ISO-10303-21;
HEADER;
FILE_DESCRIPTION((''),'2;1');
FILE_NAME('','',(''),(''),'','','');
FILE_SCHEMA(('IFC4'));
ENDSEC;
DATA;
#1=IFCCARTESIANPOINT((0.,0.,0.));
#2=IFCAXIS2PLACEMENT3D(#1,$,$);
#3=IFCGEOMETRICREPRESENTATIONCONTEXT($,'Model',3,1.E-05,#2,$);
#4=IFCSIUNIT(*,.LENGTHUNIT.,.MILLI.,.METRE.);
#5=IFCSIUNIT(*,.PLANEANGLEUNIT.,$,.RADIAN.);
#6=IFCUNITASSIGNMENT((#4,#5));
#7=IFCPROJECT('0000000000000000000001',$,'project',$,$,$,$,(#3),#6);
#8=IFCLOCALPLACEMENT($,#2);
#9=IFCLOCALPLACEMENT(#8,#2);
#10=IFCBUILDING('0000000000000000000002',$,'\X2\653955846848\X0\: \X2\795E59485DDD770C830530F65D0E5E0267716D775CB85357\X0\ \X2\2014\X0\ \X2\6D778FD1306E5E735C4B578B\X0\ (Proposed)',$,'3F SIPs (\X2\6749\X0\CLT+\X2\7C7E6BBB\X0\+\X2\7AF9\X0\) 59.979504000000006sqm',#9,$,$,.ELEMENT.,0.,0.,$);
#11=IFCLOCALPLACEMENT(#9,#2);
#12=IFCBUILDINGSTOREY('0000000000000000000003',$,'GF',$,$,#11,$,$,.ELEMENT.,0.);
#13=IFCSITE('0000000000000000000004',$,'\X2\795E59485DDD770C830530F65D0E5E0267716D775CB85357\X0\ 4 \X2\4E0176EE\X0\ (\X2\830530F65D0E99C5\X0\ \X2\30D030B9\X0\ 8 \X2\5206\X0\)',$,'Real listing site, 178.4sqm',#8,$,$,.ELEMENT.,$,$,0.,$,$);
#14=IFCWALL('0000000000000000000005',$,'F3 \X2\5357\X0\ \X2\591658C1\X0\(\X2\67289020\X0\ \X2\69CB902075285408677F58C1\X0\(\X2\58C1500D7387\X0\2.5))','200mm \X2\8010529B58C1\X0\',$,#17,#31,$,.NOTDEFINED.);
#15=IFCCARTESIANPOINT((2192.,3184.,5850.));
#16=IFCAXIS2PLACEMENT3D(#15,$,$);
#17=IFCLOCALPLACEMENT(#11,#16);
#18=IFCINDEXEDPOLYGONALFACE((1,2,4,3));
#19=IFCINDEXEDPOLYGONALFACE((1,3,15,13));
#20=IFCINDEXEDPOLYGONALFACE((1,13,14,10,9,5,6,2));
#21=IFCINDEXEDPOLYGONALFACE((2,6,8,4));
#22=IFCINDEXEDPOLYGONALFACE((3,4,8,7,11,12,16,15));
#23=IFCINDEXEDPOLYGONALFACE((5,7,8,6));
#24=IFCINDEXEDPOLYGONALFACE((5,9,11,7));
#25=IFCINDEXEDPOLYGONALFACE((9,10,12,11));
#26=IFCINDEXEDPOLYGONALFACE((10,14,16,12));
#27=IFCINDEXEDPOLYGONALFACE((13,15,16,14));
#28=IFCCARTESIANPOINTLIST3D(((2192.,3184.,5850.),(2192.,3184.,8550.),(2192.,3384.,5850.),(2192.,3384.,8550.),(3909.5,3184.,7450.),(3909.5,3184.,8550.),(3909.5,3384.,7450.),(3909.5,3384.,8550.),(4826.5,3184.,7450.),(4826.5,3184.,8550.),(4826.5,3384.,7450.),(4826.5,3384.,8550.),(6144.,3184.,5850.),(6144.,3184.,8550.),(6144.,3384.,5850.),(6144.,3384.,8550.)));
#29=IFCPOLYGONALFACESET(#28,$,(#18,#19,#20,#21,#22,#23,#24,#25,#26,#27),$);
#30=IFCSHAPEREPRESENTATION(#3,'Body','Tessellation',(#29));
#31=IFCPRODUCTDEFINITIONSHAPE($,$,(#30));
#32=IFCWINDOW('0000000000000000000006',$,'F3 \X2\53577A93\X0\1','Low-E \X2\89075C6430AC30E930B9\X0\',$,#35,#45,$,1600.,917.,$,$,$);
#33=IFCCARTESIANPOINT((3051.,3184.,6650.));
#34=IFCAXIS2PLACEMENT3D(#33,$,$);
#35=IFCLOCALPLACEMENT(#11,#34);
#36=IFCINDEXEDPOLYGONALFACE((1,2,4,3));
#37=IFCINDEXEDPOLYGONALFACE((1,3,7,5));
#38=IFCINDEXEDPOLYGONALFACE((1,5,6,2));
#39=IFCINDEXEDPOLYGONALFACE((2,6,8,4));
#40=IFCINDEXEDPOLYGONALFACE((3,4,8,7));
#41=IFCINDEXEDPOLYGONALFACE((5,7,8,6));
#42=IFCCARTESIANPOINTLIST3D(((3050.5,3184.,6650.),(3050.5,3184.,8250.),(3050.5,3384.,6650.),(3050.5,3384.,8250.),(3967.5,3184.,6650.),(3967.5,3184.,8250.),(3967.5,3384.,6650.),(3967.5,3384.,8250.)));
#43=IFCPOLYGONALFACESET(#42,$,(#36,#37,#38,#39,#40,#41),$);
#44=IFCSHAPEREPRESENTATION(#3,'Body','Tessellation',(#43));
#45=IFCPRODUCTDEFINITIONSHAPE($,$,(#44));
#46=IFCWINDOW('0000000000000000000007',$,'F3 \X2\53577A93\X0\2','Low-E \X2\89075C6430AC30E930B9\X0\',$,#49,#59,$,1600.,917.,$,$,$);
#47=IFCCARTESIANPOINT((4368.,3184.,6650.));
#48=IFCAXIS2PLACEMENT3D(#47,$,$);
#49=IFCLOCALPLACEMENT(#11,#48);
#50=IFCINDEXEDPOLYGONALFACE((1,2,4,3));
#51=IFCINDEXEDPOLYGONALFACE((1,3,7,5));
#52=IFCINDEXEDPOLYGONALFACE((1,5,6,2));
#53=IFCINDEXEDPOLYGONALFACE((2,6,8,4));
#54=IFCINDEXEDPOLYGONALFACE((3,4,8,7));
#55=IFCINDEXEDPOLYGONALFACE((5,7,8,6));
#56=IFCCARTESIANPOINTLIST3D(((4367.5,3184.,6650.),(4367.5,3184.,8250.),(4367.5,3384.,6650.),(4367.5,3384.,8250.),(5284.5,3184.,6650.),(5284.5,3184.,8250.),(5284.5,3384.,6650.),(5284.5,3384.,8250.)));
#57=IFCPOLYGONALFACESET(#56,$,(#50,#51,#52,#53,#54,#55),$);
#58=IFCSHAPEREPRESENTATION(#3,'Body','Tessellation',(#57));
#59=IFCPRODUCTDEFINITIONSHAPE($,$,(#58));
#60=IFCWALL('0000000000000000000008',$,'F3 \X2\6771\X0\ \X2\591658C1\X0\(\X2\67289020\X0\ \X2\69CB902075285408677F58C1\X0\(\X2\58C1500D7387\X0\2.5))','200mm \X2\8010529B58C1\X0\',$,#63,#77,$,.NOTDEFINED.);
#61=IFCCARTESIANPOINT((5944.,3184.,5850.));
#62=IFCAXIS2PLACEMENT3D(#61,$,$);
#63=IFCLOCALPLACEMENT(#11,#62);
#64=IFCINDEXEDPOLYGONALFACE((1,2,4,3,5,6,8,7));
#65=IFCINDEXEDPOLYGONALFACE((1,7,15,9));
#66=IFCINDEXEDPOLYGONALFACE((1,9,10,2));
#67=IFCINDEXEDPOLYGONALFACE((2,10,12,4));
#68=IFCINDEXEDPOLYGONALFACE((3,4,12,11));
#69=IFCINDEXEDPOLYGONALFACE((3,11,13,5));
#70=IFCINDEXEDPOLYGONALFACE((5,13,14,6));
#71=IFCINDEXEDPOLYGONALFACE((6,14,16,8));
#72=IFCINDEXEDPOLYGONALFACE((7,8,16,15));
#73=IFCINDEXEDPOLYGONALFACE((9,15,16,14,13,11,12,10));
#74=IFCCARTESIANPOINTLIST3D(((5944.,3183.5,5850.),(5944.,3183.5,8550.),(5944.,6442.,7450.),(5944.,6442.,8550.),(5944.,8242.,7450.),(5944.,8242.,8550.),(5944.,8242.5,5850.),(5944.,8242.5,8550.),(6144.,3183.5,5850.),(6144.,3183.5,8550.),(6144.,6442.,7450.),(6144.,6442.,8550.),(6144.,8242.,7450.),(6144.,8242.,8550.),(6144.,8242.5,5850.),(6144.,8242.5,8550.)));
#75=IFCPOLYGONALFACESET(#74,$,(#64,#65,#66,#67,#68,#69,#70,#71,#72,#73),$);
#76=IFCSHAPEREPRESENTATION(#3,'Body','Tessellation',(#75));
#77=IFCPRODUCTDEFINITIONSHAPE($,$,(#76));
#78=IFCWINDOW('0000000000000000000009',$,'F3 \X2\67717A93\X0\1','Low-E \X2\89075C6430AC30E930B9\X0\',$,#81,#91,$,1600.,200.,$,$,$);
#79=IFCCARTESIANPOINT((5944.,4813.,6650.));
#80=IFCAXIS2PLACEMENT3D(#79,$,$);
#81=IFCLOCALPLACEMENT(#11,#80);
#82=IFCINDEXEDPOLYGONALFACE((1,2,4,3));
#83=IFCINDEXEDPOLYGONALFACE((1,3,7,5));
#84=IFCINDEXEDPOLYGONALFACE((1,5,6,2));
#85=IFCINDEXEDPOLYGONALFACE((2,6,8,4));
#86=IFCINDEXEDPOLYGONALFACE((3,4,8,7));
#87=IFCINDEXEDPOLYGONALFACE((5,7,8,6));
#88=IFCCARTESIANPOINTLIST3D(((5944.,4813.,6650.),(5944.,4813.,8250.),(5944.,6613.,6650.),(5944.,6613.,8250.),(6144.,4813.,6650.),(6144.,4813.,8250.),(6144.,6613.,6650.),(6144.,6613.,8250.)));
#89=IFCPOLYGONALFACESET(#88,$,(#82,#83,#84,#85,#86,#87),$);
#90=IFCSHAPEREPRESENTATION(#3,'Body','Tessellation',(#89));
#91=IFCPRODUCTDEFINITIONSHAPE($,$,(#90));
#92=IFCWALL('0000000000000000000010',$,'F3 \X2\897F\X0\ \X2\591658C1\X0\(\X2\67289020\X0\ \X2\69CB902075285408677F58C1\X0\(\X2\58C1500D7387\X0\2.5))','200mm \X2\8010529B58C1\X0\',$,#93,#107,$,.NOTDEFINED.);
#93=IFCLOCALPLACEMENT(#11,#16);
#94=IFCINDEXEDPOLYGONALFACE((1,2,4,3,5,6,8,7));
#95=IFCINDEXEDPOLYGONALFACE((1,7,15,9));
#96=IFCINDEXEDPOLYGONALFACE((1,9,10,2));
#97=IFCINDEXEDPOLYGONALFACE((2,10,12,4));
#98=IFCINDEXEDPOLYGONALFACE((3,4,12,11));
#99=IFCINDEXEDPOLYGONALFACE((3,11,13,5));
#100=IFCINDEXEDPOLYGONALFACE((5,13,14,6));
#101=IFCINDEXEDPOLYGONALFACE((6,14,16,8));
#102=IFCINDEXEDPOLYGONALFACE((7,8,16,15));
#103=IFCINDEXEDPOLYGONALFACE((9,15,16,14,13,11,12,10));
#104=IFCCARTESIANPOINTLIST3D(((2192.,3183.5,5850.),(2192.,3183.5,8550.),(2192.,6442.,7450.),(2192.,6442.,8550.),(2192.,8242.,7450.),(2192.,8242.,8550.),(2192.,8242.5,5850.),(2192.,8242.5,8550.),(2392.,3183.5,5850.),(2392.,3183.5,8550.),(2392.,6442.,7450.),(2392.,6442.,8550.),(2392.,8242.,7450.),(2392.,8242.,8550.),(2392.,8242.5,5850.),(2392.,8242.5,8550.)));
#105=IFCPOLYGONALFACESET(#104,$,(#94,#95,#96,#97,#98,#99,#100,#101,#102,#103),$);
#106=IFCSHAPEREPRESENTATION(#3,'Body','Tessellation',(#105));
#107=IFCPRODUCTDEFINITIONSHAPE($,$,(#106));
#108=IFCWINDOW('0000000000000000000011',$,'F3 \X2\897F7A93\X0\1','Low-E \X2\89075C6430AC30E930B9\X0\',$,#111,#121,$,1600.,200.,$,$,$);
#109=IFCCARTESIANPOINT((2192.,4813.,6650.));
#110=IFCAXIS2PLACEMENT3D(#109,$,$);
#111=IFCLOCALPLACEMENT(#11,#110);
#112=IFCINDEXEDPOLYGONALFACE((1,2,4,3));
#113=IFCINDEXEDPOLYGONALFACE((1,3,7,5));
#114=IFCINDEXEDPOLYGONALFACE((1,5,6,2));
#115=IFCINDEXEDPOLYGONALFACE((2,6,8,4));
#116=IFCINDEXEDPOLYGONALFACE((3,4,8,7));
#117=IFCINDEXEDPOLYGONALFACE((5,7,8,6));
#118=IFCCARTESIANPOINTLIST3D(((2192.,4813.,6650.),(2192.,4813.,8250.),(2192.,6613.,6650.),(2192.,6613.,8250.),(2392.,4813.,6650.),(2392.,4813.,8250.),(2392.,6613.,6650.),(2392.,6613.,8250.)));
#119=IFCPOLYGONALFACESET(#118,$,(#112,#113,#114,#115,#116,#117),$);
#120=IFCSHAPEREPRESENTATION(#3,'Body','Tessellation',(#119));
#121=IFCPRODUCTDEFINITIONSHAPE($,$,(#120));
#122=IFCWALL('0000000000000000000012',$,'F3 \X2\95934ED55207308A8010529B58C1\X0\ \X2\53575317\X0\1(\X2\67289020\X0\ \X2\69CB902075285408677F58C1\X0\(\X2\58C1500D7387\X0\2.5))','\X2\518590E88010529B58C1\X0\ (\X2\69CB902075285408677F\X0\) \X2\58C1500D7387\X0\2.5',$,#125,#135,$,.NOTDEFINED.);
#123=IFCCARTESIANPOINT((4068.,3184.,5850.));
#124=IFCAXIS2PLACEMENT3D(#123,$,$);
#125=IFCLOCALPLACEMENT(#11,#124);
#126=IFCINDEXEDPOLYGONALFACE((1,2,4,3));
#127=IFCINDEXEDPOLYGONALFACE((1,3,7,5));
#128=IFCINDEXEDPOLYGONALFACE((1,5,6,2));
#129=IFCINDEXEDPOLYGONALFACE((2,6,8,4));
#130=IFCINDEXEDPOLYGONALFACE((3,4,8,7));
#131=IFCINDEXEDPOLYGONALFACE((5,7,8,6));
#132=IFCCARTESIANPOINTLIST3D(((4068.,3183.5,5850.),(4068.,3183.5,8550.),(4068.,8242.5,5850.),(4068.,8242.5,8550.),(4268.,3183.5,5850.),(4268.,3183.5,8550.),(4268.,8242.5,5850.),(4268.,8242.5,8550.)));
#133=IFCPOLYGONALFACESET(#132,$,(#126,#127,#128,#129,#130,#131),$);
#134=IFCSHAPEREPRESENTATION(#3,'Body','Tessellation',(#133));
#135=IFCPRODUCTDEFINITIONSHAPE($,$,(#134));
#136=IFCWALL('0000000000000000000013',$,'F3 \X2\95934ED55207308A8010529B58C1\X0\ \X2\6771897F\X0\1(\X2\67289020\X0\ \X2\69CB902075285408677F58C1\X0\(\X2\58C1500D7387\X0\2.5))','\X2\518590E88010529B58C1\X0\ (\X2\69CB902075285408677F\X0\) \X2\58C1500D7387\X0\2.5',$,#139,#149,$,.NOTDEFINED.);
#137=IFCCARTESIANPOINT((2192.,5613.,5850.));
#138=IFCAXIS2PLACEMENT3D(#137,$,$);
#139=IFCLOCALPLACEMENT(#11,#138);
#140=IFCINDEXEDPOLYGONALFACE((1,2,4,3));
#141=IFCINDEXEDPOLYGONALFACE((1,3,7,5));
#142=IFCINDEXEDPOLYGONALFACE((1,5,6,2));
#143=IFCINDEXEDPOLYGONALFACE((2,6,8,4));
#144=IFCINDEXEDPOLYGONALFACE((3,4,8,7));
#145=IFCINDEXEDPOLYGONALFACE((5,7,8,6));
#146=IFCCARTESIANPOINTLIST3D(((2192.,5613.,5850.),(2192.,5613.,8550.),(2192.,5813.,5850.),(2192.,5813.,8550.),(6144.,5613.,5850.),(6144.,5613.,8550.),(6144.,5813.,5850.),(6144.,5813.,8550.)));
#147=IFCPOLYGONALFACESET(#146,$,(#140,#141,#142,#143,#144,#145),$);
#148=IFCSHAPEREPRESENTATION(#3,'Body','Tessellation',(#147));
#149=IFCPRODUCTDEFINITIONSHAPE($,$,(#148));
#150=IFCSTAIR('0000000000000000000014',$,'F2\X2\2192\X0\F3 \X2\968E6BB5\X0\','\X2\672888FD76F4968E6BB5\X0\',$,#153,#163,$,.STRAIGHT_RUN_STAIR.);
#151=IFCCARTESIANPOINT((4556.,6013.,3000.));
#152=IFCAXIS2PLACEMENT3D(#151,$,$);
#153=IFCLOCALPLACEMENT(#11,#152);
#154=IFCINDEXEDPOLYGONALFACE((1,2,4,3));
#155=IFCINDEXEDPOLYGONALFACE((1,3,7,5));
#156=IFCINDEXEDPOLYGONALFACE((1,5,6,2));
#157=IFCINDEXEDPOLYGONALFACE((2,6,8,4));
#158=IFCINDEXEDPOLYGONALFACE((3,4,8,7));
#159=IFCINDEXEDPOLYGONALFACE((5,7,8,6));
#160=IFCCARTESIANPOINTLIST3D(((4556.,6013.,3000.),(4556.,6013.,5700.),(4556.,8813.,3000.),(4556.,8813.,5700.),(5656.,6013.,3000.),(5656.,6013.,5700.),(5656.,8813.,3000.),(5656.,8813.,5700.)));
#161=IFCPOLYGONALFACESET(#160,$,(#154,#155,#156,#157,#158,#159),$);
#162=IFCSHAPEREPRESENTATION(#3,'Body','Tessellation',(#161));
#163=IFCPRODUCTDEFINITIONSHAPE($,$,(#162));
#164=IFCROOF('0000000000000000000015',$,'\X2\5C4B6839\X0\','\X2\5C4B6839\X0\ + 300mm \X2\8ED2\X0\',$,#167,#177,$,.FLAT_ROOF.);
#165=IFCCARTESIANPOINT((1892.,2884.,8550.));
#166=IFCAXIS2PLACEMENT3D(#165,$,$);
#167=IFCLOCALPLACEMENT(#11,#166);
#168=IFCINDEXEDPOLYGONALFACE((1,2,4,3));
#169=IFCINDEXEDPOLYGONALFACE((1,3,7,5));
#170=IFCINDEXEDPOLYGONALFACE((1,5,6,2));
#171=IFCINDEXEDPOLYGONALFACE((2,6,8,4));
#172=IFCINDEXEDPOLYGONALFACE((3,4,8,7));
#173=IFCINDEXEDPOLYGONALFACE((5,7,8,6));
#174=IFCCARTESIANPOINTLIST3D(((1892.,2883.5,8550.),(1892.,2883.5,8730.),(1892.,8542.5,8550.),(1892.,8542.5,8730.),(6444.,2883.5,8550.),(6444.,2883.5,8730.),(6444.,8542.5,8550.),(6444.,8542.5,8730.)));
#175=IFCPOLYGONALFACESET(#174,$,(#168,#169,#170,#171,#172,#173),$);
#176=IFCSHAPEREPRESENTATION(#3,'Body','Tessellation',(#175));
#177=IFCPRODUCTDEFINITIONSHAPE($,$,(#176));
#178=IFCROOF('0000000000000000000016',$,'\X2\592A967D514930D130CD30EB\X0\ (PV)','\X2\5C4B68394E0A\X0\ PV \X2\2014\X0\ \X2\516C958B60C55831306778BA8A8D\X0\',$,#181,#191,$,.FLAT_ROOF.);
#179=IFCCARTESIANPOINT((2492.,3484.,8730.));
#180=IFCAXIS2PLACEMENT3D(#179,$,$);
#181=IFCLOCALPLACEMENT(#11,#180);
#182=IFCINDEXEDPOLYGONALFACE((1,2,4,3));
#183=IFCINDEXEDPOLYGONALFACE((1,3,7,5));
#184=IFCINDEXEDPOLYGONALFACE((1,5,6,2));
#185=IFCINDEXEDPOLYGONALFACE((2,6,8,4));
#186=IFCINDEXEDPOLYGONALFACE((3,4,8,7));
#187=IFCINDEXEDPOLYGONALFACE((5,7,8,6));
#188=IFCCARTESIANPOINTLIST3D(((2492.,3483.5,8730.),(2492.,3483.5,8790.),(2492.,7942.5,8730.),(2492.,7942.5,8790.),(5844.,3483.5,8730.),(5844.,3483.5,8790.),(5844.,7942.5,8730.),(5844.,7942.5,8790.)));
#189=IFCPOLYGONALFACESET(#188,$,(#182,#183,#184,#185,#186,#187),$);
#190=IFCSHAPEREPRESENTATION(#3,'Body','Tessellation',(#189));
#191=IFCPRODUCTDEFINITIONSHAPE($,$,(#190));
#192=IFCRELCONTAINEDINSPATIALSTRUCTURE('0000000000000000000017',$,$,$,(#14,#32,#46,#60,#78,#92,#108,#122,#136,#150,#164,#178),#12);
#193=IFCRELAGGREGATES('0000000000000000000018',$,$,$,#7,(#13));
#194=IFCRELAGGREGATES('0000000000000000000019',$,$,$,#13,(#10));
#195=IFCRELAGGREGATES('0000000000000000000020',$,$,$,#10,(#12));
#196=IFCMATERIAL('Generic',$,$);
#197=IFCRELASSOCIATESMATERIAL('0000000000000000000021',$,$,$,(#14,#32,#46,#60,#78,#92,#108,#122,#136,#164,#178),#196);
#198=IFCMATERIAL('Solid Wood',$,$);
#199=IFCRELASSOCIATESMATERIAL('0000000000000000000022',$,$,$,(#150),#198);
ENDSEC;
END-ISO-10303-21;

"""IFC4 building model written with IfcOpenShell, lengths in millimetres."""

from ifc_helpers import new_model, si_unit, frame, frame_2d, origin, place, context, project, spatial, rectangle, extrude, material, element, fill, save


model = new_model("IFC4")

# Units and contexts
model_context = context("Model", 3, precision=1e-05, world=origin())
ifc_project = project(units=[si_unit("LENGTHUNIT", "METRE", prefix="MILLI"), si_unit("PLANEANGLEUNIT", "RADIAN")], contexts=[model_context])

# Site, building, storey
site_placement = place(None, origin())
site = spatial("IfcSite", under=ifc_project, at=site_placement, Name="神奈川県茅ヶ崎市東海岸南 4 丁目 (茅ヶ崎駅 バス 8 分)", ObjectType="Real listing site, 178.4sqm", CompositionType="ELEMENT", RefElevation=0.0)
building_placement = place(site_placement, origin())
building = spatial("IfcBuilding", under=site, at=building_placement, Name="改善案: 神奈川県茅ヶ崎市東海岸南 — 海近の平屋型 (Proposed)", ObjectType="3F SIPs (杉CLT+籾殻+竹) 59.979504000000006sqm", CompositionType="ELEMENT", ElevationOfRefHeight=0.0, ElevationOfTerrain=0.0)
storey_placement = place(building_placement, origin())
storey = spatial("IfcBuildingStorey", under=building, at=storey_placement, Name="GF", CompositionType="ELEMENT", Elevation=0.0)

# Shared definitions
ifc_material_1 = material(Name="Generic")

# Wall, openings, windows
wall_1_placement = place(storey_placement, frame((2192.0, 3184.0, 5850.0)))
wall_1 = element("IfcWall", 1, at=wall_1_placement, inside=storey, material=ifc_material_1, Name="F3 南 外壁(木造 構造用合板壁(壁倍率2.5))", Description="200mm 耐力壁", PredefinedType="NOTDEFINED", context=model_context, shape_type="SweptSolid", body=[
    extrude(rectangle(XDim=3952.0, YDim=200.0, at=frame_2d((1976.0, 100.0))), frame((2192.0, 3184.0, 5850.0)), (0.0, 0.0, 1.0), 2700.0),
])
opening_1_placement = place(storey_placement, frame((3051.0, 3184.0, 6650.0)))
opening_1 = element("IfcOpeningElement", 2, at=opening_1_placement, cuts=wall_1, PredefinedType="NOTDEFINED", context=model_context, shape_type="SweptSolid", body=[
    extrude(rectangle(XDim=917.0, YDim=200.0, at=frame_2d((458.0, 100.0))), frame((3051.0, 3184.0, 6650.0)), (0.0, 0.0, 1.0), 1600.0),
])
opening_2_placement = place(storey_placement, frame((4368.0, 3184.0, 6650.0)))
opening_2 = element("IfcOpeningElement", 3, at=opening_2_placement, cuts=wall_1, PredefinedType="NOTDEFINED", context=model_context, shape_type="SweptSolid", body=[
    extrude(rectangle(XDim=917.0, YDim=200.0, at=frame_2d((458.0, 100.0))), frame((4368.0, 3184.0, 6650.0)), (0.0, 0.0, 1.0), 1600.0),
])
window_1_placement = place(storey_placement, frame((3051.0, 3184.0, 6650.0)))
window_1 = element("IfcWindow", 4, at=window_1_placement, inside=storey, material=ifc_material_1, Name="F3 南窓1", Description="Low-E 複層ガラス", OverallHeight=1600.0, OverallWidth=917.0, context=model_context, shape_type="SweptSolid", body=[
    extrude(rectangle(XDim=917.0, YDim=200.0, at=frame_2d((458.0, 100.0))), frame((3051.0, 3184.0, 6650.0)), (0.0, 0.0, 1.0), 1600.0),
])
fill(opening_1, window_1)
window_2_placement = place(storey_placement, frame((4368.0, 3184.0, 6650.0)))
window_2 = element("IfcWindow", 5, at=window_2_placement, inside=storey, material=ifc_material_1, Name="F3 南窓2", Description="Low-E 複層ガラス", OverallHeight=1600.0, OverallWidth=917.0, context=model_context, shape_type="SweptSolid", body=[
    extrude(rectangle(XDim=917.0, YDim=200.0, at=frame_2d((458.0, 100.0))), frame((4368.0, 3184.0, 6650.0)), (0.0, 0.0, 1.0), 1600.0),
])
fill(opening_2, window_2)

# Walls, openings, windows
wall_2_placement = place(storey_placement, frame((5944.0, 3184.0, 5850.0)))
wall_2 = element("IfcWall", 6, at=wall_2_placement, inside=storey, material=ifc_material_1, Name="F3 東 外壁(木造 構造用合板壁(壁倍率2.5))", Description="200mm 耐力壁", PredefinedType="NOTDEFINED", context=model_context, shape_type="SweptSolid", body=[
    extrude(rectangle(XDim=200.0, YDim=5059.0, at=frame_2d((100.0, 2529.0))), frame((5944.0, 3184.0, 5850.0)), (0.0, 0.0, 1.0), 2700.0),
])
opening_3_placement = place(storey_placement, frame((5944.0, 4813.0, 6650.0)))
opening_3 = element("IfcOpeningElement", 7, at=opening_3_placement, cuts=wall_2, PredefinedType="NOTDEFINED", context=model_context, shape_type="SweptSolid", body=[
    extrude(rectangle(XDim=200.0, YDim=1800.0, at=frame_2d((100.0, 900.0))), frame((5944.0, 4813.0, 6650.0)), (0.0, 0.0, 1.0), 1600.0),
])
window_3_placement = place(storey_placement, frame((5944.0, 4813.0, 6650.0)))
window_3 = element("IfcWindow", 8, at=window_3_placement, inside=storey, material=ifc_material_1, Name="F3 東窓1", Description="Low-E 複層ガラス", OverallHeight=1600.0, OverallWidth=200.0, context=model_context, shape_type="SweptSolid", body=[
    extrude(rectangle(XDim=200.0, YDim=1800.0, at=frame_2d((100.0, 900.0))), frame((5944.0, 4813.0, 6650.0)), (0.0, 0.0, 1.0), 1600.0),
])
fill(opening_3, window_3)
wall_3_placement = place(storey_placement, frame((2192.0, 3184.0, 5850.0)))
wall_3 = element("IfcWall", 9, at=wall_3_placement, inside=storey, material=ifc_material_1, Name="F3 西 外壁(木造 構造用合板壁(壁倍率2.5))", Description="200mm 耐力壁", PredefinedType="NOTDEFINED", context=model_context, shape_type="SweptSolid", body=[
    extrude(rectangle(XDim=200.0, YDim=5059.0, at=frame_2d((100.0, 2529.0))), frame((2192.0, 3184.0, 5850.0)), (0.0, 0.0, 1.0), 2700.0),
])
opening_4_placement = place(storey_placement, frame((2192.0, 4813.0, 6650.0)))
opening_4 = element("IfcOpeningElement", 10, at=opening_4_placement, cuts=wall_3, PredefinedType="NOTDEFINED", context=model_context, shape_type="SweptSolid", body=[
    extrude(rectangle(XDim=200.0, YDim=1800.0, at=frame_2d((100.0, 900.0))), frame((2192.0, 4813.0, 6650.0)), (0.0, 0.0, 1.0), 1600.0),
])
window_4_placement = place(storey_placement, frame((2192.0, 4813.0, 6650.0)))
window_4 = element("IfcWindow", 11, at=window_4_placement, inside=storey, material=ifc_material_1, Name="F3 西窓1", Description="Low-E 複層ガラス", OverallHeight=1600.0, OverallWidth=200.0, context=model_context, shape_type="SweptSolid", body=[
    extrude(rectangle(XDim=200.0, YDim=1800.0, at=frame_2d((100.0, 900.0))), frame((2192.0, 4813.0, 6650.0)), (0.0, 0.0, 1.0), 1600.0),
])
fill(opening_4, window_4)

# Walls
wall_4_placement = place(storey_placement, frame((4068.0, 3184.0, 5850.0)))
element("IfcWall", 12, at=wall_4_placement, inside=storey, material=ifc_material_1, Name="F3 間仕切り耐力壁 南北1(木造 構造用合板壁(壁倍率2.5))", Description="内部耐力壁 (構造用合板) 壁倍率2.5", PredefinedType="NOTDEFINED", context=model_context, shape_type="SweptSolid", body=[
    extrude(rectangle(XDim=200.0, YDim=5059.0, at=frame_2d((100.0, 2529.0))), frame((4068.0, 3184.0, 5850.0)), (0.0, 0.0, 1.0), 2700.0),
])
wall_5_placement = place(storey_placement, frame((2192.0, 5613.0, 5850.0)))
element("IfcWall", 13, at=wall_5_placement, inside=storey, material=ifc_material_1, Name="F3 間仕切り耐力壁 東西1(木造 構造用合板壁(壁倍率2.5))", Description="内部耐力壁 (構造用合板) 壁倍率2.5", PredefinedType="NOTDEFINED", context=model_context, shape_type="SweptSolid", body=[
    extrude(rectangle(XDim=3952.0, YDim=200.0, at=frame_2d((1976.0, 100.0))), frame((2192.0, 5613.0, 5850.0)), (0.0, 0.0, 1.0), 2700.0),
])

# Stair
ifc_material_2 = material(Name="Solid Wood")
stair_placement = place(storey_placement, frame((4556.0, 6013.0, 3000.0)))
element("IfcStair", 14, at=stair_placement, inside=storey, material=ifc_material_2, Name="F2→F3 階段", Description="木製直階段", PredefinedType="STRAIGHT_RUN_STAIR", context=model_context, shape_type="SweptSolid", body=[
    extrude(rectangle(XDim=1100.0, YDim=2800.0, at=frame_2d((550.0, 1400.0))), frame((4556.0, 6013.0, 3000.0)), (0.0, 0.0, 1.0), 2700.0),
])

# Roofs
roof_1_placement = place(storey_placement, frame((1892.0, 2884.0, 8550.0)))
element("IfcRoof", 15, at=roof_1_placement, inside=storey, material=ifc_material_1, Name="屋根", Description="屋根 + 300mm 軒", PredefinedType="FLAT_ROOF", context=model_context, shape_type="SweptSolid", body=[
    extrude(rectangle(XDim=4552.0, YDim=5659.0, at=frame_2d((2276.0, 2829.0))), frame((1892.0, 2884.0, 8550.0)), (0.0, 0.0, 1.0), 180.0),
])
roof_2_placement = place(storey_placement, frame((2492.0, 3484.0, 8730.0)))
element("IfcRoof", 16, at=roof_2_placement, inside=storey, material=ifc_material_1, Name="太陽光パネル (PV)", Description="屋根上 PV — 公開情報で確認", PredefinedType="FLAT_ROOF", context=model_context, shape_type="SweptSolid", body=[
    extrude(rectangle(XDim=3352.0, YDim=4459.0, at=frame_2d((1676.0, 2229.0))), frame((2492.0, 3484.0, 8730.0)), (0.0, 0.0, 1.0), 60.0),
])

save(model, "model.ifc")
